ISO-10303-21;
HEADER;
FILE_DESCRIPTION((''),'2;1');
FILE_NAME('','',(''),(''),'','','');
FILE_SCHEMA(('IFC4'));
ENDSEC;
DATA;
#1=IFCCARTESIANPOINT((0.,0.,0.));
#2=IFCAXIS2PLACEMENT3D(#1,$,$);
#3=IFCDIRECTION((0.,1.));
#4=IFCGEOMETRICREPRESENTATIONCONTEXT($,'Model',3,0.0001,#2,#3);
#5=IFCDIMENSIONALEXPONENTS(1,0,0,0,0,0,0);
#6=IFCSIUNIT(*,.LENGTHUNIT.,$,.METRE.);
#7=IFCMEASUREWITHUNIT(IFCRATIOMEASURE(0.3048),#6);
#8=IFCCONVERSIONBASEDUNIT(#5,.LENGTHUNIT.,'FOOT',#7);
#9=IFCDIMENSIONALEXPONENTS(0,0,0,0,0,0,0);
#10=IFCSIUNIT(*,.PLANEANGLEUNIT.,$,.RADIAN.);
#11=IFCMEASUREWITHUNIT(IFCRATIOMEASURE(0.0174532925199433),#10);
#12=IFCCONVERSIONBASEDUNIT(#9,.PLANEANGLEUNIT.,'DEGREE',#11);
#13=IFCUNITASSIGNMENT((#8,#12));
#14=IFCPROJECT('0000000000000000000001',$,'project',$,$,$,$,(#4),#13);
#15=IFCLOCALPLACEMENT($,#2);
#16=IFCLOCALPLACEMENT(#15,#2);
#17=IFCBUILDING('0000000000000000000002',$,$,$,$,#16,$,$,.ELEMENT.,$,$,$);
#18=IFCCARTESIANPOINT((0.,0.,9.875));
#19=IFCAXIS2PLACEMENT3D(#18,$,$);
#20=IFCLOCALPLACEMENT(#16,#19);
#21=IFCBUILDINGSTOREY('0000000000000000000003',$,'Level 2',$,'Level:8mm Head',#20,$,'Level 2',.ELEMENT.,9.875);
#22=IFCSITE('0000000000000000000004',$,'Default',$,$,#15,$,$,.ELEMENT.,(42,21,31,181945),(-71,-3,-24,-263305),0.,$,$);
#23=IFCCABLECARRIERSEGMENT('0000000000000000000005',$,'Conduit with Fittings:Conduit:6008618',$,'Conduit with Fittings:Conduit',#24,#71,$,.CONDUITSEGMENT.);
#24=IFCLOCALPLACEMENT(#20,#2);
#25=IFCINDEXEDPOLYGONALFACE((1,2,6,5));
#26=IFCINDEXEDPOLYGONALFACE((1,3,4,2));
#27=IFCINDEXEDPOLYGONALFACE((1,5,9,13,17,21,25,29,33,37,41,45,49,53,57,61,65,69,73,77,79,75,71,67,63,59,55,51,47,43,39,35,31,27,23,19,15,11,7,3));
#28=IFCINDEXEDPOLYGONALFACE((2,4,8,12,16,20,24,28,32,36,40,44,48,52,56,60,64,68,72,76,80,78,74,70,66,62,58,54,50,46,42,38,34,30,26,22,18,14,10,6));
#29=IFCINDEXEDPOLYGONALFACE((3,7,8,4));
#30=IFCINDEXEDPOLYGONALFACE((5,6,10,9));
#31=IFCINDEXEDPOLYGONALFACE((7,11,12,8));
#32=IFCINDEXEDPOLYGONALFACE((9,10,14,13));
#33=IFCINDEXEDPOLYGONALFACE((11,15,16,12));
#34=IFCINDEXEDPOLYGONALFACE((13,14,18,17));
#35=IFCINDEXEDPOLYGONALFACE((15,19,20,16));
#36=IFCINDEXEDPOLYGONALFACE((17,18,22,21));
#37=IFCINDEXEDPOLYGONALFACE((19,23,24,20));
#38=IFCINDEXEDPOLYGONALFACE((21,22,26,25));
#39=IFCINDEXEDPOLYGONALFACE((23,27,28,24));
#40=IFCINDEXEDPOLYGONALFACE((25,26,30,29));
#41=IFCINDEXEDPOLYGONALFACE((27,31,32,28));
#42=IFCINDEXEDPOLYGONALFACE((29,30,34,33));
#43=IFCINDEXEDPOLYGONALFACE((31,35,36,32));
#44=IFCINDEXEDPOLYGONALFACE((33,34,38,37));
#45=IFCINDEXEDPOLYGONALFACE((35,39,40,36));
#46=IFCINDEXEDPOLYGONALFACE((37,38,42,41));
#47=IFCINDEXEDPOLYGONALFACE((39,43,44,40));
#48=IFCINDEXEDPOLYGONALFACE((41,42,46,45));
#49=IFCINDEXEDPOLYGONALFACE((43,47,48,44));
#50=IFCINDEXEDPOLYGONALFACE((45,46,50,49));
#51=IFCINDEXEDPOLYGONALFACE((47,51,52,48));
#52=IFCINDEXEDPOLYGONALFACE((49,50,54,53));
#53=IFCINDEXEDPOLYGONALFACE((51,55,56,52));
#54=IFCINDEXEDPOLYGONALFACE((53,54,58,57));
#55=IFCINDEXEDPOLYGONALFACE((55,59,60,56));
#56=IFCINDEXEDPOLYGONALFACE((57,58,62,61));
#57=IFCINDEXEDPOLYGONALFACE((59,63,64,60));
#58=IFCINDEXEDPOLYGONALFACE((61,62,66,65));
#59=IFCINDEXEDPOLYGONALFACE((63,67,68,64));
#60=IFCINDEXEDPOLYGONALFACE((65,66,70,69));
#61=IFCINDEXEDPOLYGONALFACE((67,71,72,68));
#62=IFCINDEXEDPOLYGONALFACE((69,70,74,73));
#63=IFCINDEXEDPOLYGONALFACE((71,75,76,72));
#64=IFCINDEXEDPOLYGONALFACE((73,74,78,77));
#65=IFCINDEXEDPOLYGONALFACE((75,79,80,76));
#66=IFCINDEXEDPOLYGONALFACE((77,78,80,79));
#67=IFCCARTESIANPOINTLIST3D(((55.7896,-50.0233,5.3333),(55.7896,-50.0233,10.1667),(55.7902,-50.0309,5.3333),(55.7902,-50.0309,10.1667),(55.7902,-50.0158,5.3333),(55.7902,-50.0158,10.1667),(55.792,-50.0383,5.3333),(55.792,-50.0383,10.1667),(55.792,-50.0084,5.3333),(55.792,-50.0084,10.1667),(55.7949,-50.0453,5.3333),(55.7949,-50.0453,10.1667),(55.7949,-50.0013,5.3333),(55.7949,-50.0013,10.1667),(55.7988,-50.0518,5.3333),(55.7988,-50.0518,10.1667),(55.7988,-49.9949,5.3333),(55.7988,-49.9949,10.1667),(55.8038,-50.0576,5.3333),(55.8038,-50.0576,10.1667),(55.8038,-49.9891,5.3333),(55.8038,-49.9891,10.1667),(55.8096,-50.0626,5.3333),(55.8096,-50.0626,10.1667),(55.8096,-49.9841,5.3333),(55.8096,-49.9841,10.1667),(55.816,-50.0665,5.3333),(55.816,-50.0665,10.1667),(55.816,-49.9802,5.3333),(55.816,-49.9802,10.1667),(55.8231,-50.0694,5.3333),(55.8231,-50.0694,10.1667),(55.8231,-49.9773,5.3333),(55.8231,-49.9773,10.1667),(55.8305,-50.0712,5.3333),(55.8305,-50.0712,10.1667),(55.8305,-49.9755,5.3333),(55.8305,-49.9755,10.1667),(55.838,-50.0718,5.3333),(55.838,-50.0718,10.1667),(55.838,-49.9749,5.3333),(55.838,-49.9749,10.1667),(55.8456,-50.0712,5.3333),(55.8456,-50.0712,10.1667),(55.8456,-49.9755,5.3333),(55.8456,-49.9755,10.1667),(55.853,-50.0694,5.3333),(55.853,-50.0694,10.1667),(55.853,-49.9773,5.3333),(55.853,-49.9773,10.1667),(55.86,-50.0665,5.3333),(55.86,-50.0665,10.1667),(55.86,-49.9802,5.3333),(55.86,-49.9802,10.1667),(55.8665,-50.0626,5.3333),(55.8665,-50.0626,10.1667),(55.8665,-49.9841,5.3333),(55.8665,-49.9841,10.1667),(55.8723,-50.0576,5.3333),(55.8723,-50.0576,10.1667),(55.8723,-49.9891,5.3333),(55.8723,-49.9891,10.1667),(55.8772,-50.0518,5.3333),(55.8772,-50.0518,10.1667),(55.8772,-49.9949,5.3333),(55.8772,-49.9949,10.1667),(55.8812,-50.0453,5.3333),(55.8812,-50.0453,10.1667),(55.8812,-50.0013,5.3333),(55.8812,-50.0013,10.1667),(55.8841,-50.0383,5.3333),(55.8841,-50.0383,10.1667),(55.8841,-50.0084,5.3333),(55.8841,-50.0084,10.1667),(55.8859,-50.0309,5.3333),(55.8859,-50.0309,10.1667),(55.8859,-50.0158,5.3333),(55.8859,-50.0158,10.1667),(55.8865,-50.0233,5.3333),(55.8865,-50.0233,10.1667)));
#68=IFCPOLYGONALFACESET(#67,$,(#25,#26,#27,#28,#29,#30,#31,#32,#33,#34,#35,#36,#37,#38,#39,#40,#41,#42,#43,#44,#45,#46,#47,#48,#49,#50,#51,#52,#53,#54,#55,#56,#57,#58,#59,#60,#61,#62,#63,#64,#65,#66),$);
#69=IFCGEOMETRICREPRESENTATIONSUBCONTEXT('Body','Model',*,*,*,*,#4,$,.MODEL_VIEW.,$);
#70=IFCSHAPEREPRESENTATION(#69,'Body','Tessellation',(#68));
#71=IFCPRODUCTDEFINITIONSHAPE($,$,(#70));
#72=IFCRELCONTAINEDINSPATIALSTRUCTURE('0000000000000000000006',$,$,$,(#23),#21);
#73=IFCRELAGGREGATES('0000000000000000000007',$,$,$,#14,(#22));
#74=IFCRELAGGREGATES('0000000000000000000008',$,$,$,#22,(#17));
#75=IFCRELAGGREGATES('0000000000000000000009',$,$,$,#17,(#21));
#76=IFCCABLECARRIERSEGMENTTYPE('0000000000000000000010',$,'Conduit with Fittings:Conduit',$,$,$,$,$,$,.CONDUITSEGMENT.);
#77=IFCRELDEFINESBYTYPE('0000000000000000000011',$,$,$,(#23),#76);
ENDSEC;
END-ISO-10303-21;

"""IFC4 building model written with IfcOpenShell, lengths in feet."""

from ifc_helpers import new_model, entity, si_unit, converted_unit, direction, frame, origin, place, context, subcontext, project, spatial, indexed_curve, outline, extrude, type_object, element, save


model = new_model("IFC4")

# Units and contexts
model_context = context("Model", 3, precision=0.0001, world=origin(), true_north=direction((0.0, 1.0)))
body_context = subcontext(model_context, "Body", "Model", "MODEL_VIEW")
ifc_project = project(units=[converted_unit("LENGTHUNIT", "FOOT", entity("IfcRatioMeasure", 0.3048), si_unit("LENGTHUNIT", "METRE"), dimensions=[1, 0, 0, 0, 0, 0, 0]), converted_unit("PLANEANGLEUNIT", "DEGREE", entity("IfcRatioMeasure", 0.0174532925199433), si_unit("PLANEANGLEUNIT", "RADIAN"), dimensions=[0, 0, 0, 0, 0, 0, 0])], contexts=[model_context])

# Site, building, storey
site_placement = place(None, origin())
site = spatial("IfcSite", under=ifc_project, at=site_placement, Name="Default", CompositionType="ELEMENT", RefLatitude=(42, 21, 31, 181945), RefLongitude=(-71, -3, -24, -263305), RefElevation=0.0)
building_placement = place(site_placement, origin())
building = spatial("IfcBuilding", under=site, at=building_placement, CompositionType="ELEMENT")
storey_placement = place(building_placement, frame((0.0, 0.0, 9.875)))
storey = spatial("IfcBuildingStorey", under=building, at=storey_placement, Name="Level 2", ObjectType="Level:8mm Head", LongName="Level 2", CompositionType="ELEMENT", Elevation=9.875)

# Cable carrier segment
cable_carrier_segment_type = type_object("IfcCableCarrierSegmentType", Name="Conduit with Fittings:Conduit", PredefinedType="CONDUITSEGMENT")
cable_carrier_segment_1_placement = place(storey_placement, origin())
element("IfcCableCarrierSegment", 1, at=cable_carrier_segment_1_placement, inside=storey, type_object=cable_carrier_segment_type, Name="Conduit with Fittings:Conduit:6008618", ObjectType="Conduit with Fittings:Conduit", PredefinedType="CONDUITSEGMENT", context=body_context, shape_type="SweptSolid", body=[
    extrude(outline(indexed_curve([(0.0485, 0.0), (0.0479, 0.0076), (0.0461, 0.015), (0.0432, 0.022), (0.0392, 0.0285), (0.0343, 0.0343), (0.0285, 0.0392), (0.022, 0.0432), (0.015, 0.0461), (0.0076, 0.0479), (0.0, 0.0485), (-0.0076, 0.0479), (-0.015, 0.0461), (-0.022, 0.0432), (-0.0285, 0.0392), (-0.0343, 0.0343), (-0.0392, 0.0285), (-0.0432, 0.022), (-0.0461, 0.015), (-0.0479, 0.0076), (-0.0485, 0.0), (-0.0479, -0.0076), (-0.0461, -0.015), (-0.0432, -0.022), (-0.0392, -0.0285), (-0.0343, -0.0343), (-0.0285, -0.0392), (-0.022, -0.0432), (-0.015, -0.0461), (-0.0076, -0.0479), (0.0, -0.0485), (0.0076, -0.0479), (0.015, -0.0461), (0.022, -0.0432), (0.0285, -0.0392), (0.0343, -0.0343), (0.0392, -0.0285), (0.0432, -0.022), (0.0461, -0.015), (0.0479, -0.0076), (0.0485, 0.0)], self_intersect=False)), frame((55.838, -50.0233, 5.3333), z_axis=(0.0, 0.0, 1.0), x_axis=(-1.0, 0.0, 0.0)), (0.0, 0.0, 1.0), 4.8333),
])

save(model, "model.ifc")
